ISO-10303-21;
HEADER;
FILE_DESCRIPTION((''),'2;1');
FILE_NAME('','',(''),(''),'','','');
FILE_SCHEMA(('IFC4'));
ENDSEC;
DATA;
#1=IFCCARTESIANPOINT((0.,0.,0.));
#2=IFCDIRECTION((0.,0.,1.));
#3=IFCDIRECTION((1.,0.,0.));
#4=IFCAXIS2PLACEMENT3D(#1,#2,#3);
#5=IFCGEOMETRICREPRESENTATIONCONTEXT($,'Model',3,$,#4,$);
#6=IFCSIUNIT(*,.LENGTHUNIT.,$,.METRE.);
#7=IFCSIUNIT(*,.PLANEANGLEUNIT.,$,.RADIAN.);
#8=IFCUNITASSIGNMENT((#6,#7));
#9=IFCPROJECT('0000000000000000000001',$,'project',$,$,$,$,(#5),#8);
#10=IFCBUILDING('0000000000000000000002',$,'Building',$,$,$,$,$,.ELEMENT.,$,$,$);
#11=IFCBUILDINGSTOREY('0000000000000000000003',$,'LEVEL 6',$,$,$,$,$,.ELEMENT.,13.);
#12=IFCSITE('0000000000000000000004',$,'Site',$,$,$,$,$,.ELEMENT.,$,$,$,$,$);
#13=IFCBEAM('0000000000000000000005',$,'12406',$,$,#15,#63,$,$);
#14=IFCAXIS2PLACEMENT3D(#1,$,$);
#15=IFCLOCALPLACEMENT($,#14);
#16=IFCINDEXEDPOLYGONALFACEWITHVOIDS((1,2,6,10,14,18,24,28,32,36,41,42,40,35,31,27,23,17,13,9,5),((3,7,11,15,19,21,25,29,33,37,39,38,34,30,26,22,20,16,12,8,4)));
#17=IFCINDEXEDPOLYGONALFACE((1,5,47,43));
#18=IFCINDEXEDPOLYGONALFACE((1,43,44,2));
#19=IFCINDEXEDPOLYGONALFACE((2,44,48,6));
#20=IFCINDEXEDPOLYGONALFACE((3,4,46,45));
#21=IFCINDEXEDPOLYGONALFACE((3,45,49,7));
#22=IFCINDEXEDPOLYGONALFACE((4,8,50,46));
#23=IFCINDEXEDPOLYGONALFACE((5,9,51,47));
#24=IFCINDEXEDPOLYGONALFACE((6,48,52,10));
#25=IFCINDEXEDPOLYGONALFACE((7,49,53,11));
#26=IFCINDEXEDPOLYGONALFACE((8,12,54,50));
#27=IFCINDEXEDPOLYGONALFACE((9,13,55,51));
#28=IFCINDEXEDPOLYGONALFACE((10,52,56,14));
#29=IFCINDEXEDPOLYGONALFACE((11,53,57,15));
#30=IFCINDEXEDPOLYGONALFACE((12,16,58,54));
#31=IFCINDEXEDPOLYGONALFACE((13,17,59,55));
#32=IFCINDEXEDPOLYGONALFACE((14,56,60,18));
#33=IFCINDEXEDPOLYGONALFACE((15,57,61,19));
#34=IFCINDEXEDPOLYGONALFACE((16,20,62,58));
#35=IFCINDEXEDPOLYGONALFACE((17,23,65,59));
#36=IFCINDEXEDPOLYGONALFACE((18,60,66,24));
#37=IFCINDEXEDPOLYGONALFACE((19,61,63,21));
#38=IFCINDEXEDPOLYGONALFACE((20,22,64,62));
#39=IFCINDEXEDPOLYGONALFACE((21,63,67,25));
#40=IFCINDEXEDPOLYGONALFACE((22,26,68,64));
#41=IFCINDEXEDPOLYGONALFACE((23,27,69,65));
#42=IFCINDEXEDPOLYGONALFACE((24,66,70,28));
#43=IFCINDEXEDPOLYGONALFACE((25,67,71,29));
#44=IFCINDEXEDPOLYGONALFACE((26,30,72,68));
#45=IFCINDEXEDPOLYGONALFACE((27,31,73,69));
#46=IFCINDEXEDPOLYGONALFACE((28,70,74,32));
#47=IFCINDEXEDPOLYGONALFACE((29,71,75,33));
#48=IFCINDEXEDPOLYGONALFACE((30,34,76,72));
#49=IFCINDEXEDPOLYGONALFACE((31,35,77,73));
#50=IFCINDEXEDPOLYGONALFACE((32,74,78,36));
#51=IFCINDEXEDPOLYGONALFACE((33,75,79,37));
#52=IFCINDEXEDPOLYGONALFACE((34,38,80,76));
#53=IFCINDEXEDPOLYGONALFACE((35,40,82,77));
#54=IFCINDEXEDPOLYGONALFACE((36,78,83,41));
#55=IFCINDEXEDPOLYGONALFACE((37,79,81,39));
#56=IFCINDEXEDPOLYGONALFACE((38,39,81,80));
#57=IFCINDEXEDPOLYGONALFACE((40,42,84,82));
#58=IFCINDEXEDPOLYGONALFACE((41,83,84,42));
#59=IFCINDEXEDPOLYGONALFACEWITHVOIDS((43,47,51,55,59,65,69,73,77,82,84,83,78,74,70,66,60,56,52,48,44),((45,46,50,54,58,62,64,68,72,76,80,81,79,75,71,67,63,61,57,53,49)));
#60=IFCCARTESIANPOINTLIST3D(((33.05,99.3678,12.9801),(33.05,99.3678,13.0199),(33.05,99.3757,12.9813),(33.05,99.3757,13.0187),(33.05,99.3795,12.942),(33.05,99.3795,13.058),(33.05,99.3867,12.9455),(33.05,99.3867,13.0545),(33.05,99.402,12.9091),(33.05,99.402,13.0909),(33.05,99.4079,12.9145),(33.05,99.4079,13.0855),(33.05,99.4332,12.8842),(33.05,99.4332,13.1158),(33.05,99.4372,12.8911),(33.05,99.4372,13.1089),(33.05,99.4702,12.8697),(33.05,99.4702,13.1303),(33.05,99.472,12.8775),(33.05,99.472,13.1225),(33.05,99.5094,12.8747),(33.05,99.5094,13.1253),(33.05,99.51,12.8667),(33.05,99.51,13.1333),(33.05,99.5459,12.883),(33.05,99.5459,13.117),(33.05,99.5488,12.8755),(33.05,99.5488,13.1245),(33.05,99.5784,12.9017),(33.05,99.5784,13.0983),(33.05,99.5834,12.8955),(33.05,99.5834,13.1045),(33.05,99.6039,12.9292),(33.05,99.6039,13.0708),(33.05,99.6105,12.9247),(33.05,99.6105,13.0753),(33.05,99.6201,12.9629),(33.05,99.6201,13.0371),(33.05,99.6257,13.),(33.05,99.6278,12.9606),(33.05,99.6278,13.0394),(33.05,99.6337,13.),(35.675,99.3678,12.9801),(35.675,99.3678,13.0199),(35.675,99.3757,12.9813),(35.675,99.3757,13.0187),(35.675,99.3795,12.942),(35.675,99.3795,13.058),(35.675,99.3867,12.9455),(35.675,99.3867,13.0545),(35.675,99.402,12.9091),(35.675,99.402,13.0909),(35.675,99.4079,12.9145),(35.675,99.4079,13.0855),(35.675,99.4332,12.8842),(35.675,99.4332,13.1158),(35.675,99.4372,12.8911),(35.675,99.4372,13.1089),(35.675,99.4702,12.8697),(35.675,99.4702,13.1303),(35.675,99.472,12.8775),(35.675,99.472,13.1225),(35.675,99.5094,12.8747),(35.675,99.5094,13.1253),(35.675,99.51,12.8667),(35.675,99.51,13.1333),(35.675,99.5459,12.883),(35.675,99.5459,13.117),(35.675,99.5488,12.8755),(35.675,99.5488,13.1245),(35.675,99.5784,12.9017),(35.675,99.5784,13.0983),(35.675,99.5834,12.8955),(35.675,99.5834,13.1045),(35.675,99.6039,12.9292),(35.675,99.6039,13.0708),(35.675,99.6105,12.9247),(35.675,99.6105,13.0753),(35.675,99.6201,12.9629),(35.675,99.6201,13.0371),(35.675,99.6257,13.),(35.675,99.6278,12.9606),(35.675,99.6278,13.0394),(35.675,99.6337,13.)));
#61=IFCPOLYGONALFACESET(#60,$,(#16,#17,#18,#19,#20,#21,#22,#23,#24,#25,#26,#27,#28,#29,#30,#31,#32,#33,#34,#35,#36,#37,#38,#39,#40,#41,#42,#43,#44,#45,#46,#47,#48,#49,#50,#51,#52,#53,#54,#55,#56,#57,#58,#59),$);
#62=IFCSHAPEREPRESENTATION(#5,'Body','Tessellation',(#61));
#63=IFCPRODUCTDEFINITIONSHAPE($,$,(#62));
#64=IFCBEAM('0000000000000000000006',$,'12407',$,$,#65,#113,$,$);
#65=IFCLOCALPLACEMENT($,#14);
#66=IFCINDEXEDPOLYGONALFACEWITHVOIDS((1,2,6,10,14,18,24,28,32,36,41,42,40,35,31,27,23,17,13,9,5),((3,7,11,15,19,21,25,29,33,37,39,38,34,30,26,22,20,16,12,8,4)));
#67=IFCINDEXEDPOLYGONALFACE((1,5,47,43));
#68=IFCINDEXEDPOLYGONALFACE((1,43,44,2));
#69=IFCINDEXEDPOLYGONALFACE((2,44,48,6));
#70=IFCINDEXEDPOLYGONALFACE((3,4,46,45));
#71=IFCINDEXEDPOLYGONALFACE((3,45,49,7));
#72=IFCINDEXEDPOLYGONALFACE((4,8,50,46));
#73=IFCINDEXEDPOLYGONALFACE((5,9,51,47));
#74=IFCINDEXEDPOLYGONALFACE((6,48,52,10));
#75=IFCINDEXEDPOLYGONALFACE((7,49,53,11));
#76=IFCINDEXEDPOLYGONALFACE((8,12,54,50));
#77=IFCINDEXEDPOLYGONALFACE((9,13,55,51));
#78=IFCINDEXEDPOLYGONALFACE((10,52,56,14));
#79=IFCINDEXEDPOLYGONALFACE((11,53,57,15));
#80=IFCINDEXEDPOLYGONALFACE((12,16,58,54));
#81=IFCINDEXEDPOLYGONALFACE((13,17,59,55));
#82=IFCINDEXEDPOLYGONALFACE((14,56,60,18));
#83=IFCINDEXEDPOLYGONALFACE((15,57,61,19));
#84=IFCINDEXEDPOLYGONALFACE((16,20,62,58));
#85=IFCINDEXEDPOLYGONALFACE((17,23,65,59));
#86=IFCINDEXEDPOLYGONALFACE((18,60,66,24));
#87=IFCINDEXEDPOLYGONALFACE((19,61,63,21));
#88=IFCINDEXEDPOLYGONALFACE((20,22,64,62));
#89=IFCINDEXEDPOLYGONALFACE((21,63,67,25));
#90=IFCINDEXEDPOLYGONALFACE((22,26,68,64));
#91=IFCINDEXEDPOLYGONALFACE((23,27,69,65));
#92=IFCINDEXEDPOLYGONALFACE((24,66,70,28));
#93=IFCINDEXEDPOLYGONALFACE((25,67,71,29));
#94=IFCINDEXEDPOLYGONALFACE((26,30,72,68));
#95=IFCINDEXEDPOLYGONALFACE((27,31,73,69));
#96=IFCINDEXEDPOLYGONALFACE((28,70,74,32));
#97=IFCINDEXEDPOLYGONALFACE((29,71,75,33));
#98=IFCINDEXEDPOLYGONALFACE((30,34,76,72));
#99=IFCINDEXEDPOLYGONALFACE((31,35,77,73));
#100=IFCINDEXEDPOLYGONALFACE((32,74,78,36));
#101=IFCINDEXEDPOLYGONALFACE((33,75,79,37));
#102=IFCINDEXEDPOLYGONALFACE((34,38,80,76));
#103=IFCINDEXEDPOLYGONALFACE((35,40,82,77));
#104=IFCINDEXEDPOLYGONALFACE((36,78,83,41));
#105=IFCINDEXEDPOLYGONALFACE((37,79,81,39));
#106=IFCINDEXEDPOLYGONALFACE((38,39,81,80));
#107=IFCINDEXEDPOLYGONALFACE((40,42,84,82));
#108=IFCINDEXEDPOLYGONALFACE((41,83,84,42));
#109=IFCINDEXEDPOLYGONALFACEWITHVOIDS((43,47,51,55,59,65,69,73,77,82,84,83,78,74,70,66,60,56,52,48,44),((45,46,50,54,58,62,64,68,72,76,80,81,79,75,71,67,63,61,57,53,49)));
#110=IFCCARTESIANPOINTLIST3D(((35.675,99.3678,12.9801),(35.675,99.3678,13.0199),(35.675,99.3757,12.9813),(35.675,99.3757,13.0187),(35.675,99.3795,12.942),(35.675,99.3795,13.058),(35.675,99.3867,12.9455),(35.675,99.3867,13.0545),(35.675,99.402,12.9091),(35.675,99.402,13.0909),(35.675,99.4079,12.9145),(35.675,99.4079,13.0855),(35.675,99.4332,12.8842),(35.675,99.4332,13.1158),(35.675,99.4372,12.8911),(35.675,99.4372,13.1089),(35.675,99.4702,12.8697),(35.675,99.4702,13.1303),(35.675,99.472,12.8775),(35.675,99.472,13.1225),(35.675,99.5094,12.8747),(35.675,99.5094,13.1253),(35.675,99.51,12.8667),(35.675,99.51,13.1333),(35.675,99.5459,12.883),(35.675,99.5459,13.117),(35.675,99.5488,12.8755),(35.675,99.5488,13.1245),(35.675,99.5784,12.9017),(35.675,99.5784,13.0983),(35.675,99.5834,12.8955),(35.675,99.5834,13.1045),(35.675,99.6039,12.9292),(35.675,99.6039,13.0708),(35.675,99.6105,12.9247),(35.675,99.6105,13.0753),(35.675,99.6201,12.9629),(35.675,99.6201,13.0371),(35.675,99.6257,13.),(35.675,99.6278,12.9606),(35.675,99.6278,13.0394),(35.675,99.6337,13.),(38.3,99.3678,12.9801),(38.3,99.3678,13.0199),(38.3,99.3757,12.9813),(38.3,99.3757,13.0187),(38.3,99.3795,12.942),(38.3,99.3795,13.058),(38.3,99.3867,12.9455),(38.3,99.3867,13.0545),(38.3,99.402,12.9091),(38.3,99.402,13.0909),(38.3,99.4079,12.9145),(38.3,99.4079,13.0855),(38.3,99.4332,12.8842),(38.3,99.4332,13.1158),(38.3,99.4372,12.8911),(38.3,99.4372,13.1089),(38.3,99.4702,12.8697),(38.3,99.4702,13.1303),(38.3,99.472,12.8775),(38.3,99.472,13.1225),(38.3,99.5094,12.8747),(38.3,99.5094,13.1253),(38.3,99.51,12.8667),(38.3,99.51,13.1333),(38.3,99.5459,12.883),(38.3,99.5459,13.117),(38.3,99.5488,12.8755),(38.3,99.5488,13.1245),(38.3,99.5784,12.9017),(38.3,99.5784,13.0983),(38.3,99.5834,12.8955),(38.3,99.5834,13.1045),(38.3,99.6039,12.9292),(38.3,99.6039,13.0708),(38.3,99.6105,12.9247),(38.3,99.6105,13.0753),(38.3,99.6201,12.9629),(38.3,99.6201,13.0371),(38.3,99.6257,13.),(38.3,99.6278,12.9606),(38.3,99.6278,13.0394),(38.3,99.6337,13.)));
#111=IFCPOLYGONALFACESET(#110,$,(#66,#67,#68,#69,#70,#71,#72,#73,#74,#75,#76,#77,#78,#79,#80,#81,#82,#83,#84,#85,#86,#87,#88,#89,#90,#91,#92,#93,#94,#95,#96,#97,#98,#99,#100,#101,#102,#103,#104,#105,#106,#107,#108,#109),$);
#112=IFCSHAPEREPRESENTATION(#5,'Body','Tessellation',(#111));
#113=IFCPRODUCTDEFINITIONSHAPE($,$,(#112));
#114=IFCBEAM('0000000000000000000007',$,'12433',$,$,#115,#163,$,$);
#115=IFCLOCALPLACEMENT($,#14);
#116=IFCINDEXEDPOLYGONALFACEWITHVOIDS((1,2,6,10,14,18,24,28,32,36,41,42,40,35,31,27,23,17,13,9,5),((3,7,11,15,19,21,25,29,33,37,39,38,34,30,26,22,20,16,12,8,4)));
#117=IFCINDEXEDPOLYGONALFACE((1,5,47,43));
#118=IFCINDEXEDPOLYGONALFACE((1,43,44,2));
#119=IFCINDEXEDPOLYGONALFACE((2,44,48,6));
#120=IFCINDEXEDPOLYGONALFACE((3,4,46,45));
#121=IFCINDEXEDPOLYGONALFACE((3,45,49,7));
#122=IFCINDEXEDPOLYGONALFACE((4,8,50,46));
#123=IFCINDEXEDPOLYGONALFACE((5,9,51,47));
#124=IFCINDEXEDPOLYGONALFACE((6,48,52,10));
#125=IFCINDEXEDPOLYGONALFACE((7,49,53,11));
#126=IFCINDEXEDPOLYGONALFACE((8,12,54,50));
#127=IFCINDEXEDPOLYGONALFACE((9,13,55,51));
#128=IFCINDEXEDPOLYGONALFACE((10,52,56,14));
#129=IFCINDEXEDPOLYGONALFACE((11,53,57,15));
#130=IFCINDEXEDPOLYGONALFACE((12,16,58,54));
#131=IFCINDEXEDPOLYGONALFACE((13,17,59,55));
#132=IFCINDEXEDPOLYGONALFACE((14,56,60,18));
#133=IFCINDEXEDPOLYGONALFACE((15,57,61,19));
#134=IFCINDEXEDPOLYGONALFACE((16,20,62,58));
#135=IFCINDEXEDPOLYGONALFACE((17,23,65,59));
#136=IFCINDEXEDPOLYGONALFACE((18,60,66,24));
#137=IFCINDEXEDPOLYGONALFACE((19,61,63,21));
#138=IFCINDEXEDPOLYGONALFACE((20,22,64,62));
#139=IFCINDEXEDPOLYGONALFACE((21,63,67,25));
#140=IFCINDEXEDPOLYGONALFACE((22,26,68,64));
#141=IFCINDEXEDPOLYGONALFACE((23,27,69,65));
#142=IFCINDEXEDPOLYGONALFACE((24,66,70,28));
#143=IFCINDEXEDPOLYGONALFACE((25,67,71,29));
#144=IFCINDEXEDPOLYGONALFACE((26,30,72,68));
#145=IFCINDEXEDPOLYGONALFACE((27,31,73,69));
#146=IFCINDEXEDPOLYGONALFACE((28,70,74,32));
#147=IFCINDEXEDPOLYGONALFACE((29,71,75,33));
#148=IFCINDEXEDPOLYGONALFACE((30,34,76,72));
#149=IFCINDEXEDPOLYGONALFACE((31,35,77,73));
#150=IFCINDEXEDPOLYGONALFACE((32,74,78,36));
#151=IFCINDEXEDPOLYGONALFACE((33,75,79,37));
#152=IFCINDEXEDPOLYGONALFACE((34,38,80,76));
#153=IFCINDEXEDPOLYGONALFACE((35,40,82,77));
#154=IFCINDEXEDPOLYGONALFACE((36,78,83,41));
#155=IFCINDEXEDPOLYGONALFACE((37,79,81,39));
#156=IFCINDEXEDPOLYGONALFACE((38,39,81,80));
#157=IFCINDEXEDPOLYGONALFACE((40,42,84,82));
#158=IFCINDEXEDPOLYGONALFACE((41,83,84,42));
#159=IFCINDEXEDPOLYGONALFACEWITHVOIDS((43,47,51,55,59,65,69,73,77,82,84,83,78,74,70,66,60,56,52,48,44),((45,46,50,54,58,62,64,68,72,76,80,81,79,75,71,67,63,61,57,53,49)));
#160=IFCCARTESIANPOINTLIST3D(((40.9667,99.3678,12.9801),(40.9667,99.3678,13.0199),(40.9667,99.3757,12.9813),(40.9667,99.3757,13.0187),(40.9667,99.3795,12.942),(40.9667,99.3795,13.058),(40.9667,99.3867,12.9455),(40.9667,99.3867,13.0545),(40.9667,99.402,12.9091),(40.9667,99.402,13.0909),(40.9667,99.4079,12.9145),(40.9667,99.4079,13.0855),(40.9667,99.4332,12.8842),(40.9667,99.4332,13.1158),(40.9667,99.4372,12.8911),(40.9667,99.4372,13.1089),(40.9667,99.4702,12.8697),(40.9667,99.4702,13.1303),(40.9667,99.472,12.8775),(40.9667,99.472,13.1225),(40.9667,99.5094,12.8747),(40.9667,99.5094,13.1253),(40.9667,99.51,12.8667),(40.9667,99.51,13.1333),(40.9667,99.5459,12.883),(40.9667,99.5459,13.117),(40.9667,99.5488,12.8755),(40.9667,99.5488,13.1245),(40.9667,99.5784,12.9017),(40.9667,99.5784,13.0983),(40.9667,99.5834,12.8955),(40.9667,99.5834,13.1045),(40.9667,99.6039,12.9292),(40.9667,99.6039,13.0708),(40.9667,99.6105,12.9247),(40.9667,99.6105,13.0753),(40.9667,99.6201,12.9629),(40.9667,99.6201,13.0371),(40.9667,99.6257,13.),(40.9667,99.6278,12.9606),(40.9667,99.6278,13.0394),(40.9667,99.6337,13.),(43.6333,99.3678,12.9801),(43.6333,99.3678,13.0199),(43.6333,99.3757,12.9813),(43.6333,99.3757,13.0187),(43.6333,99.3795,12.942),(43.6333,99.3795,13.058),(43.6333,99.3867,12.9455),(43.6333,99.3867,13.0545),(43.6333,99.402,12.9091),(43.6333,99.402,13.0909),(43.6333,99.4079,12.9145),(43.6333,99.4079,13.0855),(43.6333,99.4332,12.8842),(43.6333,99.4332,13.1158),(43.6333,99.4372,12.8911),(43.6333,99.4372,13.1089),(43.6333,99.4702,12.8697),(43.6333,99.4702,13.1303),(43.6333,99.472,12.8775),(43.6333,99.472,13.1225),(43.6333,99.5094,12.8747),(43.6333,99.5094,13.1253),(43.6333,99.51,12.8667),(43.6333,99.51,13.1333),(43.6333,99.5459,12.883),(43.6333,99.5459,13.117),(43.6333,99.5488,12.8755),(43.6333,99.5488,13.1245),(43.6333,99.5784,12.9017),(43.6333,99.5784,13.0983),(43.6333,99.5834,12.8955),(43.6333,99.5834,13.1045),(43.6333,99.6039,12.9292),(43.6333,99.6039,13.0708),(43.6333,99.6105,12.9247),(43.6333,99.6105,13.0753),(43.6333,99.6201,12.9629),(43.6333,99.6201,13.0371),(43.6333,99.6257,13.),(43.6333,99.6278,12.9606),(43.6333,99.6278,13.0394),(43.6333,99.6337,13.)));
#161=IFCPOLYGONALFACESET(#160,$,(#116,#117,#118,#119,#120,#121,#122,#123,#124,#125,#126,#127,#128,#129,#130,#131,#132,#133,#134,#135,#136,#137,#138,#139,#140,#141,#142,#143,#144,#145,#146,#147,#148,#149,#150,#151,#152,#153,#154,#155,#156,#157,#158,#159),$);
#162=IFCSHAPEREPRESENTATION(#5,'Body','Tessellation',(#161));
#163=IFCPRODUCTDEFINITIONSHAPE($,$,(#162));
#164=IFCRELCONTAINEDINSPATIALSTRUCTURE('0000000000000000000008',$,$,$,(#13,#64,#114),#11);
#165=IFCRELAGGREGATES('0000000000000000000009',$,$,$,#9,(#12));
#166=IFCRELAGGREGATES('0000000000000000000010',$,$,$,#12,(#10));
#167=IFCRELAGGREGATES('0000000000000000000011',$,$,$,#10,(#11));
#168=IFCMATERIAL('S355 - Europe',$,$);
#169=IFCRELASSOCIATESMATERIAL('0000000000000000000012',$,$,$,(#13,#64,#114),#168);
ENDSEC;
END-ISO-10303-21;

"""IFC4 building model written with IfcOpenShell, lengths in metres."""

from ifc_helpers import new_model, si_unit, frame, origin_with_axes, origin_2d_with_axis, place, context, project, spatial, hollow_circle, extrude, material, material_profile, profile_set, profile_usage, element, save


model = new_model("IFC4")

# Units and contexts
model_context = context("Model", 3, world=origin_with_axes())
ifc_project = project(units=[si_unit("LENGTHUNIT", "METRE"), si_unit("PLANEANGLEUNIT", "RADIAN")], contexts=[model_context])

# Site, building, storey
site = spatial("IfcSite", under=ifc_project, Name="Site", CompositionType="ELEMENT")
building = spatial("IfcBuilding", under=site, Name="Building", CompositionType="ELEMENT")
storey = spatial("IfcBuildingStorey", under=building, Name="LEVEL 6", CompositionType="ELEMENT", Elevation=13.0)

# Shared definitions
ifc_material = material(Name="S355 - Europe")

# Beams
ifc_material_profile_1 = material_profile(ifc_material, hollow_circle(Radius=0.1337, WallThickness=0.008, at=origin_2d_with_axis()))
ifc_profile_set_1 = profile_set([ifc_material_profile_1])
ifc_profile_usage_1 = profile_usage(ifc_profile_set_1, cardinal=10)
beam_1_placement = place(None, frame((33.05, 99.5, 13.0), z_axis=(1.0, 0.0, 0.0), x_axis=(0.0, 1.0, 0.0)))
element("IfcBeam", 1, at=beam_1_placement, inside=storey, material=ifc_profile_usage_1, Name="12406", context=model_context, shape_type="SweptSolid", body=[
    extrude(hollow_circle(Radius=0.1337, WallThickness=0.008, at=origin_2d_with_axis()), origin_with_axes(), (0.0, 0.0, 1.0), 2.625),
])
ifc_material_profile_2 = material_profile(ifc_material, hollow_circle(Radius=0.1337, WallThickness=0.008, at=origin_2d_with_axis()))
ifc_profile_set_2 = profile_set([ifc_material_profile_2])
ifc_profile_usage_2 = profile_usage(ifc_profile_set_2, cardinal=10)
beam_2_placement = place(None, frame((35.675, 99.5, 13.0), z_axis=(1.0, 0.0, 0.0), x_axis=(0.0, 1.0, 0.0)))
element("IfcBeam", 2, at=beam_2_placement, inside=storey, material=ifc_profile_usage_2, Name="12407", context=model_context, shape_type="SweptSolid", body=[
    extrude(hollow_circle(Radius=0.1337, WallThickness=0.008, at=origin_2d_with_axis()), origin_with_axes(), (0.0, 0.0, 1.0), 2.625),
])
ifc_material_profile_3 = material_profile(ifc_material, hollow_circle(Radius=0.1337, WallThickness=0.008, at=origin_2d_with_axis()))
ifc_profile_set_3 = profile_set([ifc_material_profile_3])
ifc_profile_usage_3 = profile_usage(ifc_profile_set_3, cardinal=10)
beam_3_placement = place(None, frame((40.9667, 99.5, 13.0), z_axis=(1.0, 0.0, 0.0), x_axis=(0.0, 1.0, 0.0)))
element("IfcBeam", 3, at=beam_3_placement, inside=storey, material=ifc_profile_usage_3, Name="12433", context=model_context, shape_type="SweptSolid", body=[
    extrude(hollow_circle(Radius=0.1337, WallThickness=0.008, at=origin_2d_with_axis()), origin_with_axes(), (0.0, 0.0, 1.0), 2.6666),
])

save(model, "model.ifc")
